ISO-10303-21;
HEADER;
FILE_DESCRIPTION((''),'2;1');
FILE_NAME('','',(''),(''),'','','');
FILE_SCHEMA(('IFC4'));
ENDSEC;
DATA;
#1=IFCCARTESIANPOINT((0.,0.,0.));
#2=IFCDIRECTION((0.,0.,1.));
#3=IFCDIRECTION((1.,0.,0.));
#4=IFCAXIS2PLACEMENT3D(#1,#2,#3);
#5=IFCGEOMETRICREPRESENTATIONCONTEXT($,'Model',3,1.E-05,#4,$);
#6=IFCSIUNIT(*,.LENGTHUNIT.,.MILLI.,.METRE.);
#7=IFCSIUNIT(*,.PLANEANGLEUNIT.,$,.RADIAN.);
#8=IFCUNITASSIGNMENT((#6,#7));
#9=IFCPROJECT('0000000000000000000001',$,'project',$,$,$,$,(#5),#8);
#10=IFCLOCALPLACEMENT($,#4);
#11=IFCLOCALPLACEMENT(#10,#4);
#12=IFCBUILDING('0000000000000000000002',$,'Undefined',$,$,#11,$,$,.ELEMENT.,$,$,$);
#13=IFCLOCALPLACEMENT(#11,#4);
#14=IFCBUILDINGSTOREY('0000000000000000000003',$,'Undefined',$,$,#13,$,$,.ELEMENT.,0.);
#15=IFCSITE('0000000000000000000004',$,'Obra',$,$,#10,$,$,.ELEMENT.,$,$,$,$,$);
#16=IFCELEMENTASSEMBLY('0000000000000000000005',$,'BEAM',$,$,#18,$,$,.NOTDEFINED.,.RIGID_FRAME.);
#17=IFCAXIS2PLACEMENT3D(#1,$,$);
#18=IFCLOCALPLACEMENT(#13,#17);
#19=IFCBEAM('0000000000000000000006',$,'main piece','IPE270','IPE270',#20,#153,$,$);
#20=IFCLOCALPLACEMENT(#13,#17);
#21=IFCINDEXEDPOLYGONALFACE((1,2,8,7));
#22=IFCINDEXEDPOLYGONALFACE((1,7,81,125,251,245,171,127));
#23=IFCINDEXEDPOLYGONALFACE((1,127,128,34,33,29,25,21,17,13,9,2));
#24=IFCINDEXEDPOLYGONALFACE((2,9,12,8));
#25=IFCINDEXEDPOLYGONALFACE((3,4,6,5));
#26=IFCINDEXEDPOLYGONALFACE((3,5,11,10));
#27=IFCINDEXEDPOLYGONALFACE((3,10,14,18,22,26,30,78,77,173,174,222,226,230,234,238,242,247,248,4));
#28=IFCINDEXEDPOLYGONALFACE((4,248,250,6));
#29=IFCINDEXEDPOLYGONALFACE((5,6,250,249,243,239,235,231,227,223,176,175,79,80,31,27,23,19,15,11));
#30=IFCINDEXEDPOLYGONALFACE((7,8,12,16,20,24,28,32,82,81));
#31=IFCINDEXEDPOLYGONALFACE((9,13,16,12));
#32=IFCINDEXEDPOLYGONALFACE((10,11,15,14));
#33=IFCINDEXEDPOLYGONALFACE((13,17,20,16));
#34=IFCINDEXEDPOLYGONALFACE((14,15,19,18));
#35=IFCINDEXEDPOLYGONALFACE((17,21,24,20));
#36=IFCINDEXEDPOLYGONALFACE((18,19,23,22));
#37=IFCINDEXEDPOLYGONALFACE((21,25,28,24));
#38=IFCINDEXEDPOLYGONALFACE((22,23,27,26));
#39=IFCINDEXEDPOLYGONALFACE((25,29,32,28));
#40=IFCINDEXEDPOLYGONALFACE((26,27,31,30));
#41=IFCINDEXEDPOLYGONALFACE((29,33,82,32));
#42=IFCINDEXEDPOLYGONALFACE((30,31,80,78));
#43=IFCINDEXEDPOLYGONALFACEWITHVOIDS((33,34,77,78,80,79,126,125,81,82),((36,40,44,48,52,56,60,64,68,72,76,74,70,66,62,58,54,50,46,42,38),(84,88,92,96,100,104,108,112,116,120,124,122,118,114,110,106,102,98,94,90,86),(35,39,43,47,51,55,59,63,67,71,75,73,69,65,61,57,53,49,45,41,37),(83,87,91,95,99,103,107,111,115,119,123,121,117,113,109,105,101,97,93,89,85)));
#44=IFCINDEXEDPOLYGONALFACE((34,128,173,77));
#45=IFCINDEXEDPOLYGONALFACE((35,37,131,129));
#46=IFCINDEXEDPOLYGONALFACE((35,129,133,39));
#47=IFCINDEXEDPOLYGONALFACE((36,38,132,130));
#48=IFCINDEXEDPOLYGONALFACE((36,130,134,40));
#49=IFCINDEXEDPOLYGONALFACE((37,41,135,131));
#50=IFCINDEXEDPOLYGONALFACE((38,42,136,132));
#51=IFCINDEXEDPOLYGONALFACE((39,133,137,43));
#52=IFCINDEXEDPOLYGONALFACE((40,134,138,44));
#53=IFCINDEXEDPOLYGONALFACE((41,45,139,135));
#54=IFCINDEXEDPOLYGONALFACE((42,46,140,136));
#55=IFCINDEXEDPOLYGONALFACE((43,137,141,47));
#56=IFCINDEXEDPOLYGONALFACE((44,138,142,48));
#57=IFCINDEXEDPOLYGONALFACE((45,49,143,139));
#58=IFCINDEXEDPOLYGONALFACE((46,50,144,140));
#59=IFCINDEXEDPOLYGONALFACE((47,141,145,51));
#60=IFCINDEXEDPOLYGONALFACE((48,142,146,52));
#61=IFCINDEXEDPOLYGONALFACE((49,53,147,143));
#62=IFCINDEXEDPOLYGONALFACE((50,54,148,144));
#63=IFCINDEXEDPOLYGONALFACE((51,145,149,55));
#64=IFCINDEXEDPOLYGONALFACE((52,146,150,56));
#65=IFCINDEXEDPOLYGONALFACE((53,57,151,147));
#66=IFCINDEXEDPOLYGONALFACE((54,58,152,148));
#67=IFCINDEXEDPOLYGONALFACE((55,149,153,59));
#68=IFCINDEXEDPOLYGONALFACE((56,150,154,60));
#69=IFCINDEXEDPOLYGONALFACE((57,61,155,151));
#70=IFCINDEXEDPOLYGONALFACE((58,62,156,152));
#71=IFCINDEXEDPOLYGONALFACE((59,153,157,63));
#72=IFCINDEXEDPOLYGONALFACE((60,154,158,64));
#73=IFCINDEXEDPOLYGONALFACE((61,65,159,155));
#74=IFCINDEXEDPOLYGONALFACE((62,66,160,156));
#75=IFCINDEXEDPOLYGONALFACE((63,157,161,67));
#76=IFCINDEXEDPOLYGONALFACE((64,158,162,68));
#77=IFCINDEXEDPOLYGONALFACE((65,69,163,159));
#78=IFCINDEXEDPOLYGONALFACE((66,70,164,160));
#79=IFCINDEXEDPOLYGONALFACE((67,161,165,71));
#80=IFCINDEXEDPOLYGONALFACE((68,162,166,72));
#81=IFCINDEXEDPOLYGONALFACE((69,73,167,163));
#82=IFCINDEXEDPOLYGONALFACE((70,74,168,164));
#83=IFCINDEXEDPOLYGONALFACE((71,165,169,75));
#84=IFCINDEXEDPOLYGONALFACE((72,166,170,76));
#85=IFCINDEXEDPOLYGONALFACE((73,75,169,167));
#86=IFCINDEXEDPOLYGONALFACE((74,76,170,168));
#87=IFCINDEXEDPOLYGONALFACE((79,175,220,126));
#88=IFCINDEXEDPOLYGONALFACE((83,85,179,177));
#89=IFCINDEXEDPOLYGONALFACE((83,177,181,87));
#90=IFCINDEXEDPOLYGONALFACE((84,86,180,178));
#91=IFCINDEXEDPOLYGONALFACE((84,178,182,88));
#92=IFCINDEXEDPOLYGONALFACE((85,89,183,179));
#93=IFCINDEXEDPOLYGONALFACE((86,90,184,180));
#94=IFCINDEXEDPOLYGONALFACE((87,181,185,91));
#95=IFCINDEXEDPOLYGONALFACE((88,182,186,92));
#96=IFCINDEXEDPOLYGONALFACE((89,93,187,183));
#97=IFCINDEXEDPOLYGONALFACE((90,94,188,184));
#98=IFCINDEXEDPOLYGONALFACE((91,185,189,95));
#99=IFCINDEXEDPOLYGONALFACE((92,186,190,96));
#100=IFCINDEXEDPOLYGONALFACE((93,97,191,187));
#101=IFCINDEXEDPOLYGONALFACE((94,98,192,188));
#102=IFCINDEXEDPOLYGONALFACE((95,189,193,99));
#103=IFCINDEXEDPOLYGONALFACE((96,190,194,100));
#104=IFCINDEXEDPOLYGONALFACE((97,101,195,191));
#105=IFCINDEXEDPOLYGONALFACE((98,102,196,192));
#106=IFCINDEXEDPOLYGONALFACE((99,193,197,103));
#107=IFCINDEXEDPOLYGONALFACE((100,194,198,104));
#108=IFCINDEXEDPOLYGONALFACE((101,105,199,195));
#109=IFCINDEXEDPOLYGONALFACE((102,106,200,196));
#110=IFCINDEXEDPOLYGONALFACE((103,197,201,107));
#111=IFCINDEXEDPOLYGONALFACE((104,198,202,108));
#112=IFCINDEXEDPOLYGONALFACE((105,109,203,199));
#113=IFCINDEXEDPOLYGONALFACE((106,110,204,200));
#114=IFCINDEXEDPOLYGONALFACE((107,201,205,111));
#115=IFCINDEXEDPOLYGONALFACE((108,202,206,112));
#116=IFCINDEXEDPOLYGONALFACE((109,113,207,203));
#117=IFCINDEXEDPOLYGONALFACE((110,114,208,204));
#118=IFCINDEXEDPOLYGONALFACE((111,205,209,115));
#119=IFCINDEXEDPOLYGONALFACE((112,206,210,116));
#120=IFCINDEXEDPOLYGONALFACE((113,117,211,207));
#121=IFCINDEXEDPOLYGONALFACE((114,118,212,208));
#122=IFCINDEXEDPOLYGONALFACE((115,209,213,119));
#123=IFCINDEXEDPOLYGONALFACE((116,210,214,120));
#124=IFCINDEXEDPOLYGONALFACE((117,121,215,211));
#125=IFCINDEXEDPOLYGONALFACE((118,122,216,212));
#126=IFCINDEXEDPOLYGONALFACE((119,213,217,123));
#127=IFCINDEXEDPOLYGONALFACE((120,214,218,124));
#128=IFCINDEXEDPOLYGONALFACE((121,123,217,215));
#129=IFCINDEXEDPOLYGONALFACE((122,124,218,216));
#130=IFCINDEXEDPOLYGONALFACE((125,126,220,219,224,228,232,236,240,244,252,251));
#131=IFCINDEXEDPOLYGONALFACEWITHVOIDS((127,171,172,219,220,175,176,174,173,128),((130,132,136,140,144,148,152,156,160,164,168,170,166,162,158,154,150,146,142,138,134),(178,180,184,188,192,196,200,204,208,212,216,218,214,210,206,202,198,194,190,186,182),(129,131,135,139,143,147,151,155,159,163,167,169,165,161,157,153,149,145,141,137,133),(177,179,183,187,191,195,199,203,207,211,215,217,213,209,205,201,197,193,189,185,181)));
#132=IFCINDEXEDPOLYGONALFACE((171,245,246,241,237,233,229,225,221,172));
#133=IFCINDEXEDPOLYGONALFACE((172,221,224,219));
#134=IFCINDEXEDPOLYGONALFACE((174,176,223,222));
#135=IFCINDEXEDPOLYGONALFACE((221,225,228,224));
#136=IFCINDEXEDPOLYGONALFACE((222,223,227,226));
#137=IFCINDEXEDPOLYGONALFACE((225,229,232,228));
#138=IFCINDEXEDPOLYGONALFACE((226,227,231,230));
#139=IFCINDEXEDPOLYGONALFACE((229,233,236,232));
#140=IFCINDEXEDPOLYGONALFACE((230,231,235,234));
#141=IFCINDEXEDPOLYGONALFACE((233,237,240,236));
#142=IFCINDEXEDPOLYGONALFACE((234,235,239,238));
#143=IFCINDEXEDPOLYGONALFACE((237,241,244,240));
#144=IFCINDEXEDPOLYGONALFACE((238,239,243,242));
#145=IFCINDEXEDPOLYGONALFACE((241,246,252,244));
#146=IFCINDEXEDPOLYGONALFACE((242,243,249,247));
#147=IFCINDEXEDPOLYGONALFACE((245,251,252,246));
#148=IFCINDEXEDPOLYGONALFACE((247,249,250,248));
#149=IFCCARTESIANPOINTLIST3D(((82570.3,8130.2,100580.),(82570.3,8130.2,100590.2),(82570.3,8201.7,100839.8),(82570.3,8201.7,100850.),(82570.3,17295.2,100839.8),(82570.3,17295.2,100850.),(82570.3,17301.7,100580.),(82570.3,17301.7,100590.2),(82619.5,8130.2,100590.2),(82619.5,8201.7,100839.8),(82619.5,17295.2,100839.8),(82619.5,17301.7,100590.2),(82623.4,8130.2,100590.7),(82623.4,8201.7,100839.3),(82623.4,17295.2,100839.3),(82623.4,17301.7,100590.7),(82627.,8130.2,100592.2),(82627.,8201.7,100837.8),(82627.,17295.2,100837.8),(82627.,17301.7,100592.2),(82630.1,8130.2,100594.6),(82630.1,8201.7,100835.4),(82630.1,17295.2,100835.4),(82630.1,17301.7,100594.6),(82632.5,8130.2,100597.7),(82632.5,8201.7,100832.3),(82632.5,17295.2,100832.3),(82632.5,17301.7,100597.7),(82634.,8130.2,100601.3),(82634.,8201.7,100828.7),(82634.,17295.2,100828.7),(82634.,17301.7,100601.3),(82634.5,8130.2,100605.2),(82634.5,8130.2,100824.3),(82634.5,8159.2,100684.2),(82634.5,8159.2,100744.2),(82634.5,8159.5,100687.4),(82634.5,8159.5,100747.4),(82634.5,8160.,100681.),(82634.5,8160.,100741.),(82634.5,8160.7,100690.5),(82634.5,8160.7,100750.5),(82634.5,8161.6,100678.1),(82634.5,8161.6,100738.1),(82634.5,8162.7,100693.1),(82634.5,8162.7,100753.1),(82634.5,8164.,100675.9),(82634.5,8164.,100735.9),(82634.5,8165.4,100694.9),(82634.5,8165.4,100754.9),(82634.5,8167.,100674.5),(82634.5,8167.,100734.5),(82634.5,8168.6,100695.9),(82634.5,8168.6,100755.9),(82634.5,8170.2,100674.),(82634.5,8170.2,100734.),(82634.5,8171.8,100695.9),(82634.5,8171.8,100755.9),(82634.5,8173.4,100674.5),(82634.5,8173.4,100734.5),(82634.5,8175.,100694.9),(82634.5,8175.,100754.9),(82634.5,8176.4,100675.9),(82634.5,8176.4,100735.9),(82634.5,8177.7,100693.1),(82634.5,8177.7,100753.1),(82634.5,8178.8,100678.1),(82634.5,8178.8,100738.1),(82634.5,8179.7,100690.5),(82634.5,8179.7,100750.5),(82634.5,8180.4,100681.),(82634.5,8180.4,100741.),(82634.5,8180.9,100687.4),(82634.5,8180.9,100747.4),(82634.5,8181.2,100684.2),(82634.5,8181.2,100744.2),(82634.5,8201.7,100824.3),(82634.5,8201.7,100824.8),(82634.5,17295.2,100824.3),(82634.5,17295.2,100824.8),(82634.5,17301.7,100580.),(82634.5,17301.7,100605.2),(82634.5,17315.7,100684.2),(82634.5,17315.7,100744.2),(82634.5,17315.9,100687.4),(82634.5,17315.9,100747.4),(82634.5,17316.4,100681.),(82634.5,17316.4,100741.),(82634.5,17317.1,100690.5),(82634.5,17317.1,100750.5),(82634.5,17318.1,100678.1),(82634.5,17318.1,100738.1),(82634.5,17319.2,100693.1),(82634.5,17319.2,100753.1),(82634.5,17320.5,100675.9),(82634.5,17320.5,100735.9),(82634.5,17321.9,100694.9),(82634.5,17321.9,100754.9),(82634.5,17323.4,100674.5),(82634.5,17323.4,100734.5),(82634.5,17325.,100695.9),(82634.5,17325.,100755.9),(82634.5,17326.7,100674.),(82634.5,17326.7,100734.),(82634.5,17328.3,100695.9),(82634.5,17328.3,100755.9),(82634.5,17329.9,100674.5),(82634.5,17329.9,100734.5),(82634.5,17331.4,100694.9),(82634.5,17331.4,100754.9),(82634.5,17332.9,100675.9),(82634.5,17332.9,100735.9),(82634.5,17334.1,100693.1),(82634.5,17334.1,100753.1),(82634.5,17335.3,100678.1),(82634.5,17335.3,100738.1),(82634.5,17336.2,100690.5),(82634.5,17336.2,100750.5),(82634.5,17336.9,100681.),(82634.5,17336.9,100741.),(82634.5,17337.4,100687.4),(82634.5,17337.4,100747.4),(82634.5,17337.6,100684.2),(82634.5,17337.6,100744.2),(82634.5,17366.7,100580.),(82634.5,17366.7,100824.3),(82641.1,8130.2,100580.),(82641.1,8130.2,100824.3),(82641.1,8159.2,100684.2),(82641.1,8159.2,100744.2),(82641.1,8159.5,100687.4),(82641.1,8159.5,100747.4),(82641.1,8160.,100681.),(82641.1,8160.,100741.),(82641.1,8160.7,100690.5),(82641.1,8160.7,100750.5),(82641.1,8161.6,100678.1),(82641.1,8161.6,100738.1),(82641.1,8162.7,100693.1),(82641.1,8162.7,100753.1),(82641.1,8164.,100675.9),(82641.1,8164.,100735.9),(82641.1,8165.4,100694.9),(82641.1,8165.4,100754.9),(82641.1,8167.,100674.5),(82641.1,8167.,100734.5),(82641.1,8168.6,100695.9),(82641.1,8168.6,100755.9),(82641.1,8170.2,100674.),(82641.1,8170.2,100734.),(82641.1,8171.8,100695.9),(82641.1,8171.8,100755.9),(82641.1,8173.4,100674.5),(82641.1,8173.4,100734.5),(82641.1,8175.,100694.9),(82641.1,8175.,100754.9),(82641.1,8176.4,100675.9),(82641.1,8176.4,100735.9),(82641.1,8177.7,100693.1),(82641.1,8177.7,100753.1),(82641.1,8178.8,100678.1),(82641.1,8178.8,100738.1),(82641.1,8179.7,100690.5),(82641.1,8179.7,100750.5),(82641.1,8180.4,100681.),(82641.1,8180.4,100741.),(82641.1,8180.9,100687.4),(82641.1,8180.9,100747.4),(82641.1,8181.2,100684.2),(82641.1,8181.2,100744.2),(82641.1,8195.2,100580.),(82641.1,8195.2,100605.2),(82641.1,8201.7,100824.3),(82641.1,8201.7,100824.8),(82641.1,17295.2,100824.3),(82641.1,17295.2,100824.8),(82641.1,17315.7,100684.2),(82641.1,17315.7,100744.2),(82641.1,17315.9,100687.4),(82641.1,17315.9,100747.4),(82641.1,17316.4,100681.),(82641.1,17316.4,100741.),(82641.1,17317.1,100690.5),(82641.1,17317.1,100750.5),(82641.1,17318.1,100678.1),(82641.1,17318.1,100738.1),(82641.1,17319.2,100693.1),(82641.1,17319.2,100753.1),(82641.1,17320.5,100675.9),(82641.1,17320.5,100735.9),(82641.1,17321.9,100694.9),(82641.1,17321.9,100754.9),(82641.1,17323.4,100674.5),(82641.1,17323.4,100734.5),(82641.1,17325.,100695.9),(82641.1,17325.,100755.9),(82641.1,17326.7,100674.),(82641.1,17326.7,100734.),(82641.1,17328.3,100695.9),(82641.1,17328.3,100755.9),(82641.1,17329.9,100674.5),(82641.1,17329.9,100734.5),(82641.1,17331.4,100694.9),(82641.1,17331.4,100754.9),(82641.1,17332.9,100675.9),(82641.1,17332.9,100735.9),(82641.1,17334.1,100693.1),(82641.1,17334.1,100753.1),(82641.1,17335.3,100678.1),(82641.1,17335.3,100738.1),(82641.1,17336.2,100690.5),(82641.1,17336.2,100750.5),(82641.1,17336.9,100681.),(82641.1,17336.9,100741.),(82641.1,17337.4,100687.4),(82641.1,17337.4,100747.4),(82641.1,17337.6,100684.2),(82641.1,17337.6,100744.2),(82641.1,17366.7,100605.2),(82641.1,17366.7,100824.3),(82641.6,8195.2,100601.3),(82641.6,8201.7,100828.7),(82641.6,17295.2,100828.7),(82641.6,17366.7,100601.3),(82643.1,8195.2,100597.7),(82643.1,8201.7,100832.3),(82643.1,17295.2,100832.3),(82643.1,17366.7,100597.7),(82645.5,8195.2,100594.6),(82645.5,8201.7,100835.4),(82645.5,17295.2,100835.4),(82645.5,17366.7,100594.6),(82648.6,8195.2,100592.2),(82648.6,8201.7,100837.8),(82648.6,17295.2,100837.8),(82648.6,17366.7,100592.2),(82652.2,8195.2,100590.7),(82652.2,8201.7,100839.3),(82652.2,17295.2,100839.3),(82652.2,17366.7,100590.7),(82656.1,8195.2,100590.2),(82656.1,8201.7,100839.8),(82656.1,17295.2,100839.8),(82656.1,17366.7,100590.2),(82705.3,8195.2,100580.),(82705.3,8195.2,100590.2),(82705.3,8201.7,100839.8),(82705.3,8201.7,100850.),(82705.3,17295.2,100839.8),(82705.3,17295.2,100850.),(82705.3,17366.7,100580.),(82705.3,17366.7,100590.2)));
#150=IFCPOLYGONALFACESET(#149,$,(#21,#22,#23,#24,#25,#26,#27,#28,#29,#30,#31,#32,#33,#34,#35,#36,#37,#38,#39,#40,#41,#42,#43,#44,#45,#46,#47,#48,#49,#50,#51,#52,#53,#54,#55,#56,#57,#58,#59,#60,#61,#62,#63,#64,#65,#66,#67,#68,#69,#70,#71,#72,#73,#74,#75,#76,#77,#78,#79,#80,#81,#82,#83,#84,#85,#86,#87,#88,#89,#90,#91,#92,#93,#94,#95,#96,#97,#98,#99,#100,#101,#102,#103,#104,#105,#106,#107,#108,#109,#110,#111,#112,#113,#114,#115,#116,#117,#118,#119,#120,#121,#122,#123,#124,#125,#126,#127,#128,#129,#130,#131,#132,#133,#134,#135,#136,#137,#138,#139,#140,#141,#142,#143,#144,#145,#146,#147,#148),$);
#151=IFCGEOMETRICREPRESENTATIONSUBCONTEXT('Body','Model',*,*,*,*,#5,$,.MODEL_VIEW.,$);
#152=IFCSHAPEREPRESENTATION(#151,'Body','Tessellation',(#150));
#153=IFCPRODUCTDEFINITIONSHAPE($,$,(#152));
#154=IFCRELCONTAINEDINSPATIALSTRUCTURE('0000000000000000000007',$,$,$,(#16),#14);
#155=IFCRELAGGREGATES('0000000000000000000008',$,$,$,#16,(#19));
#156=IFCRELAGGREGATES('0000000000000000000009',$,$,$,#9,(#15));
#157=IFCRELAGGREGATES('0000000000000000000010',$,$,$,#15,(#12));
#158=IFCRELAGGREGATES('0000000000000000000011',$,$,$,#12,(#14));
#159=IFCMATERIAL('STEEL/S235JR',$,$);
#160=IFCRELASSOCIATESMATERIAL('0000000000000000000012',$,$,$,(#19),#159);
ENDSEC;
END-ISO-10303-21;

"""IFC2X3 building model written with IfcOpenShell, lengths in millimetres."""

from ifc_helpers import new_model, si_unit, frame, origin_with_axes, origin_2d_with_axis, place, context, subcontext, project, spatial, rectangle, circle, i_section, extrude, clip, halfspace, source, transform, mapped, material, element, aggregate, save


model = new_model("IFC2X3")

# Units and contexts
model_context = context("Model", 3, precision=1e-05, world=origin_with_axes())
body_context = subcontext(model_context, "Body", "Model", "MODEL_VIEW")
ifc_project = project(units=[si_unit("LENGTHUNIT", "METRE", prefix="MILLI"), si_unit("PLANEANGLEUNIT", "RADIAN")], contexts=[model_context])

# Site, building, storey
site_placement = place(None, origin_with_axes())
site = spatial("IfcSite", under=ifc_project, at=site_placement, Name="Obra", CompositionType="ELEMENT")
building_placement = place(site_placement, origin_with_axes())
building = spatial("IfcBuilding", under=site, at=building_placement, Name="Undefined", CompositionType="ELEMENT")
storey_placement = place(building_placement, origin_with_axes())
storey = spatial("IfcBuildingStorey", under=building, at=storey_placement, Name="Undefined", CompositionType="ELEMENT", Elevation=0.0)

# Shared definitions
ifc_material = material(Name="STEEL/S235JR")

# Element assembly, beam, openings
shared_shape = source(origin_with_axes(), body_context, "Body", "SweptSolid", [
    extrude(circle(Radius=11.0, at=origin_2d_with_axis()), frame((0.0, -3.4, 0.0), z_axis=(0.0, 1.0, 0.0), x_axis=(1.0, 0.0, 0.0)), (0.0, 0.0, 1.0), 6.8),
])
assembly_1_placement = place(storey_placement, origin_with_axes())
assembly_1 = element("IfcElementAssembly", 1, at=assembly_1_placement, inside=storey, Name="BEAM", AssemblyPlace="NOTDEFINED", PredefinedType="RIGID_FRAME")
beam_1_placement = place(assembly_1_placement, frame((82637.8, 17285.2, 100715.0), z_axis=(0.0, 0.0, 1.0), x_axis=(0.0, -1.0, 0.0)))
beam_1 = element("IfcBeam", 2, at=beam_1_placement, material=ifc_material, Name="main piece", Description="IPE270", ObjectType="IPE270", context=body_context, shape_type="Clipping", body=[
    clip(clip(extrude(i_section(OverallWidth=135.0, OverallDepth=270.0, WebThickness=6.6, FlangeThickness=10.2, FilletRadius=15.0, at=origin_2d_with_axis()), frame((9155.0, 0.0, 0.0), z_axis=(-1.0, 0.0, 0.0), x_axis=(0.0, -1.0, 0.0)), (0.0, 0.0, 1.0), 9236.5), halfspace(frame((9155.0, 0.0, -235.0), z_axis=(-1.0, 0.0, 0.0), x_axis=(0.0, 1.0, 0.0)), True)), halfspace(frame((-81.5, 0.0, -235.0), z_axis=(1.0, 0.0, 0.0), x_axis=(0.0, -1.0, 0.0)), True)),
])
opening_1_placement = place(assembly_1_placement, frame((82637.8, 17285.2, 100715.0), z_axis=(0.0, 0.0, 1.0), x_axis=(0.0, -1.0, 0.0)))
element("IfcOpeningElement", 3, at=opening_1_placement, cuts=beam_1, ObjectType="Recess", context=body_context, shape_type="SweptSolid", body=[
    extrude(rectangle(XDim=75.0, YDim=300.0, at=origin_2d_with_axis()), frame((-54.0, -153.3, 124.3), z_axis=(0.0, 0.0, -1.0), x_axis=(1.0, 0.0, 0.0)), (0.0, 0.0, 1.0), 278.6),
])
opening_2_placement = place(assembly_1_placement, frame((82637.8, 17285.2, 100715.0), z_axis=(0.0, 0.0, 1.0), x_axis=(0.0, -1.0, 0.0)))
element("IfcOpeningElement", 4, at=opening_2_placement, cuts=beam_1, ObjectType="Recess", context=body_context, shape_type="SweptSolid", body=[
    extrude(rectangle(XDim=26.7, YDim=83.5, at=origin_2d_with_axis()), frame((-51.7, -68.5, 122.7), z_axis=(0.0, 1.0, 0.0), x_axis=(0.0, 0.0, -1.0)), (0.0, 0.0, 1.0), 137.0),
])
opening_3_placement = place(assembly_1_placement, frame((82637.8, 17285.2, 100715.0), z_axis=(0.0, 0.0, 1.0), x_axis=(0.0, -1.0, 0.0)))
element("IfcOpeningElement", 5, at=opening_3_placement, cuts=beam_1, ObjectType="Recess", context=body_context, shape_type="SweptSolid", body=[
    extrude(rectangle(XDim=75.0, YDim=300.0, at=origin_2d_with_axis()), frame((9127.5, 153.3, 124.3), z_axis=(0.0, 0.0, -1.0), x_axis=(-1.0, 0.0, 0.0)), (0.0, 0.0, 1.0), 278.6),
])
opening_4_placement = place(assembly_1_placement, frame((82637.8, 17285.2, 100715.0), z_axis=(0.0, 0.0, 1.0), x_axis=(0.0, -1.0, 0.0)))
element("IfcOpeningElement", 6, at=opening_4_placement, cuts=beam_1, ObjectType="Recess", context=body_context, shape_type="SweptSolid", body=[
    extrude(rectangle(XDim=26.7, YDim=83.5, at=origin_2d_with_axis()), frame((9125.3, 68.5, 122.7), z_axis=(0.0, -1.0, 0.0), x_axis=(0.0, 0.0, -1.0)), (0.0, 0.0, 1.0), 137.0),
])
opening_5_placement = place(assembly_1_placement, frame((82637.8, 17366.7, 100850.0), z_axis=(0.0, -1.0, 0.0), x_axis=(0.0, 0.0, -1.0)))
element("IfcOpeningElement", 7, at=opening_5_placement, cuts=beam_1, ObjectType="Opening", context=body_context, shape_type="MappedRepresentation", body=[
    mapped(shared_shape, transform((105.0, 0.0, 40.0))),
    mapped(shared_shape, transform((165.0, 0.0, 40.0))),
])
opening_6_placement = place(assembly_1_placement, frame((82637.8, 8130.2, 100850.0), z_axis=(0.0, 1.0, 0.0), x_axis=(0.0, 0.0, -1.0)))
element("IfcOpeningElement", 8, at=opening_6_placement, cuts=beam_1, ObjectType="Opening", context=body_context, shape_type="MappedRepresentation", body=[
    mapped(shared_shape, transform((105.0, 0.0, 40.0))),
    mapped(shared_shape, transform((165.0, 0.0, 40.0))),
])
aggregate(assembly_1, [beam_1])

save(model, "model.ifc")
